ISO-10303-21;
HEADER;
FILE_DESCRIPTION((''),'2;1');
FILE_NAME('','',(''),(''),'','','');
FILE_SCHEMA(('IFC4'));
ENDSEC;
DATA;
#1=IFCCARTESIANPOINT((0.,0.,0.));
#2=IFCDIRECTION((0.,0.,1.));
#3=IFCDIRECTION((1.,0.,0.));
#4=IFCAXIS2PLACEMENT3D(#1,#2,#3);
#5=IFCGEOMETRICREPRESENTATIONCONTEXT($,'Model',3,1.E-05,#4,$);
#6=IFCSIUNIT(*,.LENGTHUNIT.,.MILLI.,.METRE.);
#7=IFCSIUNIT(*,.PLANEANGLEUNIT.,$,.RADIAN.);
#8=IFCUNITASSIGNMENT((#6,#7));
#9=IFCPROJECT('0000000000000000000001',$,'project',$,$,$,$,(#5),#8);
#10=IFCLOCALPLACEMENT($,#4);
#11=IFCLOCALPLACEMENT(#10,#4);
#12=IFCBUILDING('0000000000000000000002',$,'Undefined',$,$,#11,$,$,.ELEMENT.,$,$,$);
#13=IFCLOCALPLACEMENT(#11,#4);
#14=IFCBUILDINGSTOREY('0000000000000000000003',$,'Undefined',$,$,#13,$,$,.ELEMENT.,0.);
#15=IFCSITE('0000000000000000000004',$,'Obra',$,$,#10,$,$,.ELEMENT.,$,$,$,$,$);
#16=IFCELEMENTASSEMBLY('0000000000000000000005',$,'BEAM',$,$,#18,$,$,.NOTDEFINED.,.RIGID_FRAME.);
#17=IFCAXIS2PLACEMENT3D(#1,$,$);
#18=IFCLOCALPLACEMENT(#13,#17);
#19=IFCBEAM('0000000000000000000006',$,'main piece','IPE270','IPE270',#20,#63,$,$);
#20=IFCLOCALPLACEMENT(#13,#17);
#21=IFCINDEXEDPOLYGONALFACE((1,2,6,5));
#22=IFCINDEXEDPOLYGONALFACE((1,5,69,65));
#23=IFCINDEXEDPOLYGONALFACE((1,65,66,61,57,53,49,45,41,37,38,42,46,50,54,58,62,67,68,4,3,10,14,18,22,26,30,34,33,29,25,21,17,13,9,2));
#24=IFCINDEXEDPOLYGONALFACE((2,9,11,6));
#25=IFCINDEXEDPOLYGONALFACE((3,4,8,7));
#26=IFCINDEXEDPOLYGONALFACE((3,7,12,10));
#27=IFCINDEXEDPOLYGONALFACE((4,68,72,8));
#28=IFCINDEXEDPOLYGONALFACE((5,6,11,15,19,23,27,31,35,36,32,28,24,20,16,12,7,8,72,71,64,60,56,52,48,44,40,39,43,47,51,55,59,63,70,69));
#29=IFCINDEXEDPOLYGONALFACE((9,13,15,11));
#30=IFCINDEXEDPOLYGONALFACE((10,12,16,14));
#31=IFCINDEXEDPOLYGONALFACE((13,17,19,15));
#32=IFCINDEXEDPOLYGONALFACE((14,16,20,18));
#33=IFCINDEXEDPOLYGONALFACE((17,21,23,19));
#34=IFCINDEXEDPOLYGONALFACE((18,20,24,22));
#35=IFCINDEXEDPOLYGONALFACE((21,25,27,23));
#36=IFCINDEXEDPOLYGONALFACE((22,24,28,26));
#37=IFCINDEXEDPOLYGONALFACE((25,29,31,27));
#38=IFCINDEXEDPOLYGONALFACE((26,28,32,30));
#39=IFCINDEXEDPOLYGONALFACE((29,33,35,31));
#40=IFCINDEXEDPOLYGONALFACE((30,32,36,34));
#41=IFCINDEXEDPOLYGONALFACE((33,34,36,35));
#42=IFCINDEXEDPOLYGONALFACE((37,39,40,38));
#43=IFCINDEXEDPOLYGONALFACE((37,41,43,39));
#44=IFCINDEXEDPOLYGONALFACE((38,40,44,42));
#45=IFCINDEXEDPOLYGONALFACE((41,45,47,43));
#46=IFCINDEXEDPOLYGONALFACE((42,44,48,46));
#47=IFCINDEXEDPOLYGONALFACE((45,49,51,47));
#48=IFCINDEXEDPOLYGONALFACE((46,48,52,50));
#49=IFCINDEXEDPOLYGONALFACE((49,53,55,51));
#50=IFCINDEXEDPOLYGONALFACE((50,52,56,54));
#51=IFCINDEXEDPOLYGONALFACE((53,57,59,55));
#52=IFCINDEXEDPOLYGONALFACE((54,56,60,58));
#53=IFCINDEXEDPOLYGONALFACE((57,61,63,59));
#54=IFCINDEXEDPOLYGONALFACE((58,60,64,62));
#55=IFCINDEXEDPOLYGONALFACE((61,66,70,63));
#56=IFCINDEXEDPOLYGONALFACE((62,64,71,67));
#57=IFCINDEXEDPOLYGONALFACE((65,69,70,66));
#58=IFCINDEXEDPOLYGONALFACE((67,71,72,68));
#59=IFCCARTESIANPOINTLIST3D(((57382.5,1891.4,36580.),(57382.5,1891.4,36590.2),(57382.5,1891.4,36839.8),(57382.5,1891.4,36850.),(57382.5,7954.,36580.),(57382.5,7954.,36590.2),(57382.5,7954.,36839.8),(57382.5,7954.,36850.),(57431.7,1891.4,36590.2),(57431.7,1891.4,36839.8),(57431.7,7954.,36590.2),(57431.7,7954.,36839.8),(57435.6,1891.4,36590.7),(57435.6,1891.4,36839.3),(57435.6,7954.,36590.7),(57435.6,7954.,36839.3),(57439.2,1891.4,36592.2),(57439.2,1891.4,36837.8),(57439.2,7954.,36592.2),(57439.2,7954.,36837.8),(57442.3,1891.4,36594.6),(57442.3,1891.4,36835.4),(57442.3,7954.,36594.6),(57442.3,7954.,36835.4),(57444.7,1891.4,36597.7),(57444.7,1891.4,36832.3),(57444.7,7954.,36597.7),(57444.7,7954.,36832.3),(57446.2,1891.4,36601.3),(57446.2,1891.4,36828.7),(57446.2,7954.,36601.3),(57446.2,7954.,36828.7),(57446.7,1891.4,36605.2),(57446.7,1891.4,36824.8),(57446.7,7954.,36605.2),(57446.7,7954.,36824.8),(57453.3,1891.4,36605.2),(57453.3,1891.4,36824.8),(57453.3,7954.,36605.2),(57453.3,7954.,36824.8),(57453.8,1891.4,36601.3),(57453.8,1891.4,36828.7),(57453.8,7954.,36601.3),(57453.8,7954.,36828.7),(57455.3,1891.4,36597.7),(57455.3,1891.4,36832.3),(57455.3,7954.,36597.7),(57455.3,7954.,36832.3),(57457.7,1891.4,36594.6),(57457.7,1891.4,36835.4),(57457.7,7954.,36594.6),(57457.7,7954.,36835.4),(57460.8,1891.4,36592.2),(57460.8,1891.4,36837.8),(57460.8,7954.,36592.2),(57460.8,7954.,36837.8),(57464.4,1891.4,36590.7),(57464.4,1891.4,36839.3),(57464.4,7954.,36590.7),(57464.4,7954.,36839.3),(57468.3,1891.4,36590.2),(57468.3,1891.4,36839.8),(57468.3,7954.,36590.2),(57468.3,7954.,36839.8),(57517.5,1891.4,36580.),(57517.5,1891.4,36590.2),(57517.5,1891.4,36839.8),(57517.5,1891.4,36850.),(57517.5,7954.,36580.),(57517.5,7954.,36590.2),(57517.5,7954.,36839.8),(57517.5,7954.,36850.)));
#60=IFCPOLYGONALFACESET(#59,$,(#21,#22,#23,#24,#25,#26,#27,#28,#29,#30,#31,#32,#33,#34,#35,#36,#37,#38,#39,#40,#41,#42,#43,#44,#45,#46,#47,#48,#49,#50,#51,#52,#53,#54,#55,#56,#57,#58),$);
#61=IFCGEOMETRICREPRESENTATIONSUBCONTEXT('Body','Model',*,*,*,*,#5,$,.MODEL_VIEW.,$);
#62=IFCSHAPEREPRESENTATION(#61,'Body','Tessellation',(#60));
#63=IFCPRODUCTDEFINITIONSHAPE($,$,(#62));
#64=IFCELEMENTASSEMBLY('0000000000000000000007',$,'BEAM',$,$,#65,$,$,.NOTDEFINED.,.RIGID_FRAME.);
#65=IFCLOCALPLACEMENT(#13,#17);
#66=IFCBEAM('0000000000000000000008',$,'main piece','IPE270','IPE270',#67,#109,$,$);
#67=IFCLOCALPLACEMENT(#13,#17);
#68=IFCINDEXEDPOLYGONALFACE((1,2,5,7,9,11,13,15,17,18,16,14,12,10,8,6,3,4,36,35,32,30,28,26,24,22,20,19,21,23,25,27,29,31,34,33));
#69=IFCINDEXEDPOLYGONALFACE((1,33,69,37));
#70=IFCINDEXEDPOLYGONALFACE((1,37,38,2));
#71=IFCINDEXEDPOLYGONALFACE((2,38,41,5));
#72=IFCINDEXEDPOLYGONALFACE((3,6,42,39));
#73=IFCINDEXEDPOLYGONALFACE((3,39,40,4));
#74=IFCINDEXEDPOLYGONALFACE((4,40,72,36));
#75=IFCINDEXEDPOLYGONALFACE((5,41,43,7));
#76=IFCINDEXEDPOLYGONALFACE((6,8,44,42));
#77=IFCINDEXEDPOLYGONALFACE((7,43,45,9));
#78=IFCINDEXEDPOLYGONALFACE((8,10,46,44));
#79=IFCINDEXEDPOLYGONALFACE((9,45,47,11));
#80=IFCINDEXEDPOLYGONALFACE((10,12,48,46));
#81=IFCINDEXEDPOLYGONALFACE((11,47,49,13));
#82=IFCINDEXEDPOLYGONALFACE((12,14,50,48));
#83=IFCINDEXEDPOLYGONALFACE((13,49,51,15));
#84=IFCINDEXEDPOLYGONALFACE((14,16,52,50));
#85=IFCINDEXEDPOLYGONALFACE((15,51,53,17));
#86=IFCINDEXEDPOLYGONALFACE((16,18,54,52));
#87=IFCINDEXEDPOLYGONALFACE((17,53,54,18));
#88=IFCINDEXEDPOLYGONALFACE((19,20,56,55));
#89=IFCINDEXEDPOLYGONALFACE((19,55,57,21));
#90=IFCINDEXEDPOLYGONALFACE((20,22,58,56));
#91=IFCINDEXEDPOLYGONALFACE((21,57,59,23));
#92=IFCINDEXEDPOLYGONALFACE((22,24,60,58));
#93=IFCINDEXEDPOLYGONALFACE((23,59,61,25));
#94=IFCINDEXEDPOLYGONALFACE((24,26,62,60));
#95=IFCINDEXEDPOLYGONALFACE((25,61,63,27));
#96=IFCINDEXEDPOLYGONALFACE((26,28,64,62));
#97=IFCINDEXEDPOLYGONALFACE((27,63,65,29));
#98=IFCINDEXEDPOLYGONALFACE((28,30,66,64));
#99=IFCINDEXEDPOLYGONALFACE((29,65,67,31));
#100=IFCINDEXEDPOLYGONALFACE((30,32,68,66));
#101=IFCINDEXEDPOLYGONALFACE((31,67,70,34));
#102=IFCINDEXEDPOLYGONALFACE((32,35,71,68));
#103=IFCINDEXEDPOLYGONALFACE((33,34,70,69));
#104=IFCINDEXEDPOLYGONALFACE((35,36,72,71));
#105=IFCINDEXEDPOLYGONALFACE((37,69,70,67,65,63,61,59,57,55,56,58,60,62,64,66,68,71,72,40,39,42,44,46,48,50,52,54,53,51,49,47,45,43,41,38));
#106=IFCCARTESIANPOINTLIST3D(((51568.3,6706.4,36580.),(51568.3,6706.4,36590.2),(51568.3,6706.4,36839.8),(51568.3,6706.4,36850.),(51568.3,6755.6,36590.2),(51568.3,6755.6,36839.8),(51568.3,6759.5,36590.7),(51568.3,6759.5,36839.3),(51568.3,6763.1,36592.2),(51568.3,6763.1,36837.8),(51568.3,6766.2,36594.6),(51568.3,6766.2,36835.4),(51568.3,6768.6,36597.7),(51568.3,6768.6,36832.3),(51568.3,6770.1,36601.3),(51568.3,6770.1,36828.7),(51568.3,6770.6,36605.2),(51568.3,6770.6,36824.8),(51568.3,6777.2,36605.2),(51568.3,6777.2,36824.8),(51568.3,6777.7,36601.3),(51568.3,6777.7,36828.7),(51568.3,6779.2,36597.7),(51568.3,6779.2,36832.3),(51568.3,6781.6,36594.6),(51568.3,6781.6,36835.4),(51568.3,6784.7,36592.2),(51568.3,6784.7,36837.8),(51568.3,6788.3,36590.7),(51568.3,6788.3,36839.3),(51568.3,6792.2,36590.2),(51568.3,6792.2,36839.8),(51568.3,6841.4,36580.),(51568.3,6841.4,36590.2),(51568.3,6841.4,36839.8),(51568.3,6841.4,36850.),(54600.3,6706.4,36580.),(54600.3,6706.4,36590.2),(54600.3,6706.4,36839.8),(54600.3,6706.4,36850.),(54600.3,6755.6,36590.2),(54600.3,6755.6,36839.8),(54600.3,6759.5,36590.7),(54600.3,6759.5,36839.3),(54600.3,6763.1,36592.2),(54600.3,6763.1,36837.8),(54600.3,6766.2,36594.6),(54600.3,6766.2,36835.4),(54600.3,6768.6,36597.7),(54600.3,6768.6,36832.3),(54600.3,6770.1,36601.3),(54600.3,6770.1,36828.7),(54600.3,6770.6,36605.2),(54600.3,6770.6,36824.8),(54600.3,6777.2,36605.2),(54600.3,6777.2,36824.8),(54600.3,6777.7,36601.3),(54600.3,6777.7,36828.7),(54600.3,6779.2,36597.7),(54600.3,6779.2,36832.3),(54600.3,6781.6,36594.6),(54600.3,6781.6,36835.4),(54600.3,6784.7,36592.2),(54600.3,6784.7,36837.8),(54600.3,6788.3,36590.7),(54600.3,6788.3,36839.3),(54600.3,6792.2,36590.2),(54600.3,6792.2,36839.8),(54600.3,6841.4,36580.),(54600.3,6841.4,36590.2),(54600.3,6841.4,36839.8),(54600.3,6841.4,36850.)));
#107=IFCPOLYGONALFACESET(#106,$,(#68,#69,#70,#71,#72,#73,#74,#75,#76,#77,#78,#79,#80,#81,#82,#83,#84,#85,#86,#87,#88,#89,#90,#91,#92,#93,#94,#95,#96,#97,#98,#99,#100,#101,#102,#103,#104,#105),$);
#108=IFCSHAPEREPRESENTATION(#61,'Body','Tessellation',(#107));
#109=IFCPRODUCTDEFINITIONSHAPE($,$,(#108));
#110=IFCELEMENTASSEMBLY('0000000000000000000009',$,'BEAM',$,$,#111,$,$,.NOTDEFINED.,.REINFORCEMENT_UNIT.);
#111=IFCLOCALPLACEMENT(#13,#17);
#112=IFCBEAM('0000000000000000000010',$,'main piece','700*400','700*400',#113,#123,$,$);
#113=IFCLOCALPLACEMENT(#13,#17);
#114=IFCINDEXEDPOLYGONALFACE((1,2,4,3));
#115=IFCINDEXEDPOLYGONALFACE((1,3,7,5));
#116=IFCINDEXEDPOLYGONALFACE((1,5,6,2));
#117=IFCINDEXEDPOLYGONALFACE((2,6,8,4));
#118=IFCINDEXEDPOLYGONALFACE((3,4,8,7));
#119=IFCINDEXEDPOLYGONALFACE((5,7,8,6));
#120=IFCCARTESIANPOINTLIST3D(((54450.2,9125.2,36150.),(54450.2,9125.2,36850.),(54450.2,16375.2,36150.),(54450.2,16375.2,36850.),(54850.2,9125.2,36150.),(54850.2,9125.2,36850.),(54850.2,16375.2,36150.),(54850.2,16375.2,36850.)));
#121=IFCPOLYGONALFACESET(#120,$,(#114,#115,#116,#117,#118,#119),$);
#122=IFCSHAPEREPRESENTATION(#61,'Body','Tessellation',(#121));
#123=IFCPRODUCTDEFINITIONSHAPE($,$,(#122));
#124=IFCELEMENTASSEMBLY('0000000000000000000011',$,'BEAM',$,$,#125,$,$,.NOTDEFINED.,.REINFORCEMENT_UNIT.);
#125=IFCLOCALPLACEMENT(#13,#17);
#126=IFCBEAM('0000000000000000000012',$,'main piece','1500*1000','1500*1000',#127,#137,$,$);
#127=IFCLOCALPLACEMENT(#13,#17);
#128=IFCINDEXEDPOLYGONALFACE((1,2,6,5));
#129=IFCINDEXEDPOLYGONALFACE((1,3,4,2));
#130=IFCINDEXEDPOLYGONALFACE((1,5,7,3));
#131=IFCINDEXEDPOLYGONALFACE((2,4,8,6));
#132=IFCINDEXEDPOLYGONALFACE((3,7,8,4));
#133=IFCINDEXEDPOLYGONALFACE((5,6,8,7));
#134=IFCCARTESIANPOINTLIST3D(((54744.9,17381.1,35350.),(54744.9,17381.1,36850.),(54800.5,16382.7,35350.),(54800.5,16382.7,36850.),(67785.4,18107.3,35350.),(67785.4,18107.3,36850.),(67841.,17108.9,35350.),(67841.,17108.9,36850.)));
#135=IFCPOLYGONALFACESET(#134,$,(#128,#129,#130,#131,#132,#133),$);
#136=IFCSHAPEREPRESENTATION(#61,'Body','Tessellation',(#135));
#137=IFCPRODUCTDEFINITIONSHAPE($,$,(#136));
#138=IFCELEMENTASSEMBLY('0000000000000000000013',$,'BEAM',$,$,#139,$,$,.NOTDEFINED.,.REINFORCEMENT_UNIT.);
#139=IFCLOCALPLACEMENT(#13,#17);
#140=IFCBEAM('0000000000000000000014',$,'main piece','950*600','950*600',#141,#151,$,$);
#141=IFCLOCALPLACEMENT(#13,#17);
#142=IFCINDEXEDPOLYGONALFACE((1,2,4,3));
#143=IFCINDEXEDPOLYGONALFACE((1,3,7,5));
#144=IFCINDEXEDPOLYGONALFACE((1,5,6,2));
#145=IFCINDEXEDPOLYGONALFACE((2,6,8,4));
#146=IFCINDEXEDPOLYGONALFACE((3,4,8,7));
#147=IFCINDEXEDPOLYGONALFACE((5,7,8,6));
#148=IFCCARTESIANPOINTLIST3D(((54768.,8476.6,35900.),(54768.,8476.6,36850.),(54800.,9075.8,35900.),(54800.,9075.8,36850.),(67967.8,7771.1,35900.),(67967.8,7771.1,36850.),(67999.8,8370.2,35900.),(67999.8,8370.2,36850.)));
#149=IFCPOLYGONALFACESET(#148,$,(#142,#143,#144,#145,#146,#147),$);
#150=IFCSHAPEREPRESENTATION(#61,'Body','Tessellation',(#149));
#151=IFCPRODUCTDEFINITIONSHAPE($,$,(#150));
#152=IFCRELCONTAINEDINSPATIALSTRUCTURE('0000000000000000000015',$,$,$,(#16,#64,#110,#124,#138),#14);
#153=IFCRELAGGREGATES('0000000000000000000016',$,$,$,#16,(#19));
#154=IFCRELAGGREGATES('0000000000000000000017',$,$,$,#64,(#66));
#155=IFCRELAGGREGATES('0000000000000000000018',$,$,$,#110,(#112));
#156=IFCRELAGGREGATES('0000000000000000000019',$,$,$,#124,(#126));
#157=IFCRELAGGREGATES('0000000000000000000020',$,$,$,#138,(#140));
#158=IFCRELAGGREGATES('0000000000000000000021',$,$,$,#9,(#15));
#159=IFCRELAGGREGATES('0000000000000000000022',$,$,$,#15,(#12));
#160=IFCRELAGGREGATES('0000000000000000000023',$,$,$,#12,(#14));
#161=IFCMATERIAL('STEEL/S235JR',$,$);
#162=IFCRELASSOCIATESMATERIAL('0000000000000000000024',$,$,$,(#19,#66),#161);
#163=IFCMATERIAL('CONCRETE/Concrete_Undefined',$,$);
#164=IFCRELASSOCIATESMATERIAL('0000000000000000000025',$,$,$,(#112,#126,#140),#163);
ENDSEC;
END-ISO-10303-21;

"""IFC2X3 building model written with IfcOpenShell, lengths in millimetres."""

from ifc_helpers import new_model, si_unit, frame, origin_with_axes, origin_2d_with_axis, place, context, subcontext, project, spatial, rectangle, i_section, extrude, material, element, aggregate, save


model = new_model("IFC2X3")

# Units and contexts
model_context = context("Model", 3, precision=1e-05, world=origin_with_axes())
body_context = subcontext(model_context, "Body", "Model", "MODEL_VIEW")
ifc_project = project(units=[si_unit("LENGTHUNIT", "METRE", prefix="MILLI"), si_unit("PLANEANGLEUNIT", "RADIAN")], contexts=[model_context])

# Site, building, storey
site_placement = place(None, origin_with_axes())
site = spatial("IfcSite", under=ifc_project, at=site_placement, Name="Obra", CompositionType="ELEMENT")
building_placement = place(site_placement, origin_with_axes())
building = spatial("IfcBuilding", under=site, at=building_placement, Name="Undefined", CompositionType="ELEMENT")
storey_placement = place(building_placement, origin_with_axes())
storey = spatial("IfcBuildingStorey", under=building, at=storey_placement, Name="Undefined", CompositionType="ELEMENT", Elevation=0.0)

# Element assemblies, beams
ifc_material_1 = material(Name="CONCRETE/Concrete_Undefined")
ifc_material_2 = material(Name="STEEL/S235JR")
assembly_1_placement = place(storey_placement, origin_with_axes())
assembly_1 = element("IfcElementAssembly", 1, at=assembly_1_placement, inside=storey, Name="BEAM", AssemblyPlace="NOTDEFINED", PredefinedType="RIGID_FRAME")
beam_1_placement = place(assembly_1_placement, frame((57450.0, 1891.4, 36715.0), z_axis=(0.0, 0.0, 1.0), x_axis=(0.0, 1.0, 0.0)))
beam_1 = element("IfcBeam", 2, at=beam_1_placement, material=ifc_material_2, Name="main piece", Description="IPE270", ObjectType="IPE270", context=body_context, shape_type="SweptSolid", body=[
    extrude(i_section(OverallWidth=135.0, OverallDepth=270.0, WebThickness=6.6, FlangeThickness=10.2, FilletRadius=15.0, at=origin_2d_with_axis()), frame((6062.6, 0.0, 0.0), z_axis=(-1.0, 0.0, 0.0), x_axis=(0.0, -1.0, 0.0)), (0.0, 0.0, 1.0), 6062.6),
])
aggregate(assembly_1, [beam_1])
assembly_2_placement = place(storey_placement, origin_with_axes())
assembly_2 = element("IfcElementAssembly", 3, at=assembly_2_placement, inside=storey, Name="BEAM", AssemblyPlace="NOTDEFINED", PredefinedType="RIGID_FRAME")
beam_2_placement = place(assembly_2_placement, frame((51568.3, 6773.9, 36715.0), z_axis=(0.0, 0.0, 1.0), x_axis=(1.0, 0.0, 0.0)))
beam_2 = element("IfcBeam", 4, at=beam_2_placement, material=ifc_material_2, Name="main piece", Description="IPE270", ObjectType="IPE270", context=body_context, shape_type="SweptSolid", body=[
    extrude(i_section(OverallWidth=135.0, OverallDepth=270.0, WebThickness=6.6, FlangeThickness=10.2, FilletRadius=15.0, at=origin_2d_with_axis()), frame((3031.9, 0.0, 0.0), z_axis=(-1.0, 0.0, 0.0), x_axis=(0.0, -1.0, 0.0)), (0.0, 0.0, 1.0), 3031.9),
])
aggregate(assembly_2, [beam_2])
assembly_3_placement = place(storey_placement, origin_with_axes())
assembly_3 = element("IfcElementAssembly", 5, at=assembly_3_placement, inside=storey, Name="BEAM", AssemblyPlace="NOTDEFINED", PredefinedType="REINFORCEMENT_UNIT")
beam_3_placement = place(assembly_3_placement, frame((54650.2, 9125.2, 36500.0), z_axis=(0.0, 0.0, 1.0), x_axis=(-0.000002, 1.0, 0.0)))
beam_3 = element("IfcBeam", 6, at=beam_3_placement, material=ifc_material_1, Name="main piece", Description="700*400", ObjectType="700*400", context=body_context, shape_type="SweptSolid", body=[
    extrude(rectangle(XDim=400.0, YDim=700.0, at=origin_2d_with_axis()), frame((7250.0, 0.0, 0.0), z_axis=(-1.0, 0.0, 0.0), x_axis=(0.0, -1.0, 0.0)), (0.0, 0.0, 1.0), 7250.0),
])
aggregate(assembly_3, [beam_3])
assembly_4_placement = place(storey_placement, origin_with_axes())
assembly_4 = element("IfcElementAssembly", 7, at=assembly_4_placement, inside=storey, Name="BEAM", AssemblyPlace="NOTDEFINED", PredefinedType="REINFORCEMENT_UNIT")
beam_4_placement = place(assembly_4_placement, frame((54772.7, 16881.9, 36100.0), z_axis=(0.0, 0.0, 1.0), x_axis=(0.998453, 0.055602, 0.0)))
beam_4 = element("IfcBeam", 8, at=beam_4_placement, material=ifc_material_1, Name="main piece", Description="1500*1000", ObjectType="1500*1000", context=body_context, shape_type="SweptSolid", body=[
    extrude(rectangle(XDim=1000.0, YDim=1500.0, at=origin_2d_with_axis()), frame((13060.8, 0.0, 0.0), z_axis=(-1.0, 0.0, 0.0), x_axis=(0.0, -1.0, 0.0)), (0.0, 0.0, 1.0), 13060.8),
])
aggregate(assembly_4, [beam_4])
assembly_5_placement = place(storey_placement, origin_with_axes())
assembly_5 = element("IfcElementAssembly", 9, at=assembly_5_placement, inside=storey, Name="BEAM", AssemblyPlace="NOTDEFINED", PredefinedType="REINFORCEMENT_UNIT")
beam_5_placement = place(assembly_5_placement, frame((54784.0, 8776.2, 36375.0), z_axis=(0.0, 0.0, 1.0), x_axis=(0.998574, -0.053378, 0.0)))
beam_5 = element("IfcBeam", 10, at=beam_5_placement, material=ifc_material_1, Name="main piece", Description="950*600", ObjectType="950*600", context=body_context, shape_type="SweptSolid", body=[
    extrude(rectangle(XDim=600.0, YDim=950.0, at=origin_2d_with_axis()), frame((13218.6, 0.0, 0.0), z_axis=(-1.0, 0.0, 0.0), x_axis=(0.0, -1.0, 0.0)), (0.0, 0.0, 1.0), 13218.6),
])
aggregate(assembly_5, [beam_5])

save(model, "model.ifc")
